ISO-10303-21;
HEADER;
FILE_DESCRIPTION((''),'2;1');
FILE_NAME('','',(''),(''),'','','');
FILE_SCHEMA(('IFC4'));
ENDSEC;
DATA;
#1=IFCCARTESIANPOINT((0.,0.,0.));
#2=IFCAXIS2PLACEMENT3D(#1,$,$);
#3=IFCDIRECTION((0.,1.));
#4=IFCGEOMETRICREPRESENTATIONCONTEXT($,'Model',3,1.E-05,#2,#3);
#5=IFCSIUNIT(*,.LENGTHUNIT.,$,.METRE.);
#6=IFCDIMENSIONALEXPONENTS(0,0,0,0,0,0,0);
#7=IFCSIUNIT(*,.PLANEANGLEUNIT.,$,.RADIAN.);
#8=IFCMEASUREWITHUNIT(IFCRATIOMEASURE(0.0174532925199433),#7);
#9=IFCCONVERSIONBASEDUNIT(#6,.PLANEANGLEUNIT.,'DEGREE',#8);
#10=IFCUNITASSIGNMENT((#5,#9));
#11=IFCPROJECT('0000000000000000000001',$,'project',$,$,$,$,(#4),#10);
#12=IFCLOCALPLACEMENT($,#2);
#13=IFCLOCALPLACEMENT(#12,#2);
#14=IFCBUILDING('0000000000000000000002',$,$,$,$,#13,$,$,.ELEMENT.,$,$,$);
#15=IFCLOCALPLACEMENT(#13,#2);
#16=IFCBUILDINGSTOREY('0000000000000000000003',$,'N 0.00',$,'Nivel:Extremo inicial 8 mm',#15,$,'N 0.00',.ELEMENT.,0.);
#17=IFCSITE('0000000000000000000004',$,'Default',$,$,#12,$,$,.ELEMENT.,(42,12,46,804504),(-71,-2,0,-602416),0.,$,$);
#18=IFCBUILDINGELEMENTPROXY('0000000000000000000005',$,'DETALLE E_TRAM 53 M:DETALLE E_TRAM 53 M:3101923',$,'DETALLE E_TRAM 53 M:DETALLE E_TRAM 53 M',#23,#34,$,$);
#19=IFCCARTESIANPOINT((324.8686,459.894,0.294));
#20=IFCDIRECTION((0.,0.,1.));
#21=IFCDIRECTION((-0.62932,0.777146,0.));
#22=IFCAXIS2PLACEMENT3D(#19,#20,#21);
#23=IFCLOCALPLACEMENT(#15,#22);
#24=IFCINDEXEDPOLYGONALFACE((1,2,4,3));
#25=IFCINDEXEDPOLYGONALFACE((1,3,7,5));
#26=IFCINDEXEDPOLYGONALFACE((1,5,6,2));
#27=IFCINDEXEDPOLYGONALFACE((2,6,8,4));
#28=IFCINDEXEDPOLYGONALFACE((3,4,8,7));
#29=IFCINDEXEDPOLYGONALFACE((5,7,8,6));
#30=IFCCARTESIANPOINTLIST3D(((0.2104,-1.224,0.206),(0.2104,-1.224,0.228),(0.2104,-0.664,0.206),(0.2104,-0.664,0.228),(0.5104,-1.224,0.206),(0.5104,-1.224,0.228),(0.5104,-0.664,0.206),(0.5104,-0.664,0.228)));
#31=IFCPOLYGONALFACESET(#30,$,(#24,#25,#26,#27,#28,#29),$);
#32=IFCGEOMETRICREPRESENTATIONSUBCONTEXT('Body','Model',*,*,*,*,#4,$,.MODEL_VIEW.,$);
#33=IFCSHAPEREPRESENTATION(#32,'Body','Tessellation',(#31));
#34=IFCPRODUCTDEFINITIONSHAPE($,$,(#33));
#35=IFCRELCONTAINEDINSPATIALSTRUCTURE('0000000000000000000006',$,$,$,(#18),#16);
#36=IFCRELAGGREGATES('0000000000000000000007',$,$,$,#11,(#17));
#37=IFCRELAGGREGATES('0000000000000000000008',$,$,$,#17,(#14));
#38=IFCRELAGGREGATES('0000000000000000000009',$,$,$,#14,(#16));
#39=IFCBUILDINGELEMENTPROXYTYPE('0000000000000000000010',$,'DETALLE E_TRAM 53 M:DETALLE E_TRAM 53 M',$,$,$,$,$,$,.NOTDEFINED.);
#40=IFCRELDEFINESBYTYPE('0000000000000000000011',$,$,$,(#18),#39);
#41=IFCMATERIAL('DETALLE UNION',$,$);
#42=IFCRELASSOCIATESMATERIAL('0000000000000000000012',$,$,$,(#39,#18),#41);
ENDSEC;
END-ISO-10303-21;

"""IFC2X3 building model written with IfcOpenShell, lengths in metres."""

from ifc_helpers import new_model, entity, si_unit, converted_unit, direction, frame, frame_2d, origin, place, context, subcontext, project, spatial, rectangle, extrude, source, transform, mapped, material, type_object, type_shapes, element, save


model = new_model("IFC2X3")

# Units and contexts
model_context = context("Model", 3, precision=1e-05, world=origin(), true_north=direction((0.0, 1.0)))
body_context = subcontext(model_context, "Body", "Model", "MODEL_VIEW")
ifc_project = project(units=[si_unit("LENGTHUNIT", "METRE"), converted_unit("PLANEANGLEUNIT", "DEGREE", entity("IfcRatioMeasure", 0.0174532925199433), si_unit("PLANEANGLEUNIT", "RADIAN"), dimensions=[0, 0, 0, 0, 0, 0, 0])], contexts=[model_context])

# Site, building, storey
site_placement = place(None, origin())
site = spatial("IfcSite", under=ifc_project, at=site_placement, Name="Default", CompositionType="ELEMENT", RefLatitude=(42, 12, 46, 804504), RefLongitude=(-71, -2, 0, -602416), RefElevation=0.0)
building_placement = place(site_placement, origin())
building = spatial("IfcBuilding", under=site, at=building_placement, CompositionType="ELEMENT")
storey_placement = place(building_placement, origin())
storey = spatial("IfcBuildingStorey", under=building, at=storey_placement, Name="N 0.00", ObjectType="Nivel:Extremo inicial 8 mm", LongName="N 0.00", CompositionType="ELEMENT", Elevation=0.0)

# Building element proxy
ifc_material_1 = material(Name="DETALLE UNION")
building_element_proxy_type_1 = type_object("IfcBuildingElementProxyType", Name="DETALLE E_TRAM 53 M:DETALLE E_TRAM 53 M", PredefinedType="NOTDEFINED", material=ifc_material_1)
shared_shape_1 = source(origin(), body_context, "Body", "SweptSolid", [
    extrude(rectangle(XDim=0.3, YDim=0.56, at=frame_2d((0.0, 0.0), x_axis=(1.0, 0.0))), frame((0.3604, -0.944, 0.206), z_axis=(0.0, 0.0, 1.0), x_axis=(-1.0, 0.0, 0.0)), (0.0, 0.0, 1.0), 0.022),
])
type_shapes(building_element_proxy_type_1, [shared_shape_1])
proxy_1_placement = place(storey_placement, frame((324.8686, 459.894, 0.294), z_axis=(0.0, 0.0, 1.0), x_axis=(-0.62932, 0.777146, 0.0)))
element("IfcBuildingElementProxy", 1, at=proxy_1_placement, inside=storey, type_object=building_element_proxy_type_1, material=ifc_material_1, Name="DETALLE E_TRAM 53 M:DETALLE E_TRAM 53 M:3101923", ObjectType="DETALLE E_TRAM 53 M:DETALLE E_TRAM 53 M", context=body_context, shape_type="MappedRepresentation", body=[
    mapped(shared_shape_1, transform((0.0, 0.0, 0.0), scale=1.0)),
])

save(model, "model.ifc")
